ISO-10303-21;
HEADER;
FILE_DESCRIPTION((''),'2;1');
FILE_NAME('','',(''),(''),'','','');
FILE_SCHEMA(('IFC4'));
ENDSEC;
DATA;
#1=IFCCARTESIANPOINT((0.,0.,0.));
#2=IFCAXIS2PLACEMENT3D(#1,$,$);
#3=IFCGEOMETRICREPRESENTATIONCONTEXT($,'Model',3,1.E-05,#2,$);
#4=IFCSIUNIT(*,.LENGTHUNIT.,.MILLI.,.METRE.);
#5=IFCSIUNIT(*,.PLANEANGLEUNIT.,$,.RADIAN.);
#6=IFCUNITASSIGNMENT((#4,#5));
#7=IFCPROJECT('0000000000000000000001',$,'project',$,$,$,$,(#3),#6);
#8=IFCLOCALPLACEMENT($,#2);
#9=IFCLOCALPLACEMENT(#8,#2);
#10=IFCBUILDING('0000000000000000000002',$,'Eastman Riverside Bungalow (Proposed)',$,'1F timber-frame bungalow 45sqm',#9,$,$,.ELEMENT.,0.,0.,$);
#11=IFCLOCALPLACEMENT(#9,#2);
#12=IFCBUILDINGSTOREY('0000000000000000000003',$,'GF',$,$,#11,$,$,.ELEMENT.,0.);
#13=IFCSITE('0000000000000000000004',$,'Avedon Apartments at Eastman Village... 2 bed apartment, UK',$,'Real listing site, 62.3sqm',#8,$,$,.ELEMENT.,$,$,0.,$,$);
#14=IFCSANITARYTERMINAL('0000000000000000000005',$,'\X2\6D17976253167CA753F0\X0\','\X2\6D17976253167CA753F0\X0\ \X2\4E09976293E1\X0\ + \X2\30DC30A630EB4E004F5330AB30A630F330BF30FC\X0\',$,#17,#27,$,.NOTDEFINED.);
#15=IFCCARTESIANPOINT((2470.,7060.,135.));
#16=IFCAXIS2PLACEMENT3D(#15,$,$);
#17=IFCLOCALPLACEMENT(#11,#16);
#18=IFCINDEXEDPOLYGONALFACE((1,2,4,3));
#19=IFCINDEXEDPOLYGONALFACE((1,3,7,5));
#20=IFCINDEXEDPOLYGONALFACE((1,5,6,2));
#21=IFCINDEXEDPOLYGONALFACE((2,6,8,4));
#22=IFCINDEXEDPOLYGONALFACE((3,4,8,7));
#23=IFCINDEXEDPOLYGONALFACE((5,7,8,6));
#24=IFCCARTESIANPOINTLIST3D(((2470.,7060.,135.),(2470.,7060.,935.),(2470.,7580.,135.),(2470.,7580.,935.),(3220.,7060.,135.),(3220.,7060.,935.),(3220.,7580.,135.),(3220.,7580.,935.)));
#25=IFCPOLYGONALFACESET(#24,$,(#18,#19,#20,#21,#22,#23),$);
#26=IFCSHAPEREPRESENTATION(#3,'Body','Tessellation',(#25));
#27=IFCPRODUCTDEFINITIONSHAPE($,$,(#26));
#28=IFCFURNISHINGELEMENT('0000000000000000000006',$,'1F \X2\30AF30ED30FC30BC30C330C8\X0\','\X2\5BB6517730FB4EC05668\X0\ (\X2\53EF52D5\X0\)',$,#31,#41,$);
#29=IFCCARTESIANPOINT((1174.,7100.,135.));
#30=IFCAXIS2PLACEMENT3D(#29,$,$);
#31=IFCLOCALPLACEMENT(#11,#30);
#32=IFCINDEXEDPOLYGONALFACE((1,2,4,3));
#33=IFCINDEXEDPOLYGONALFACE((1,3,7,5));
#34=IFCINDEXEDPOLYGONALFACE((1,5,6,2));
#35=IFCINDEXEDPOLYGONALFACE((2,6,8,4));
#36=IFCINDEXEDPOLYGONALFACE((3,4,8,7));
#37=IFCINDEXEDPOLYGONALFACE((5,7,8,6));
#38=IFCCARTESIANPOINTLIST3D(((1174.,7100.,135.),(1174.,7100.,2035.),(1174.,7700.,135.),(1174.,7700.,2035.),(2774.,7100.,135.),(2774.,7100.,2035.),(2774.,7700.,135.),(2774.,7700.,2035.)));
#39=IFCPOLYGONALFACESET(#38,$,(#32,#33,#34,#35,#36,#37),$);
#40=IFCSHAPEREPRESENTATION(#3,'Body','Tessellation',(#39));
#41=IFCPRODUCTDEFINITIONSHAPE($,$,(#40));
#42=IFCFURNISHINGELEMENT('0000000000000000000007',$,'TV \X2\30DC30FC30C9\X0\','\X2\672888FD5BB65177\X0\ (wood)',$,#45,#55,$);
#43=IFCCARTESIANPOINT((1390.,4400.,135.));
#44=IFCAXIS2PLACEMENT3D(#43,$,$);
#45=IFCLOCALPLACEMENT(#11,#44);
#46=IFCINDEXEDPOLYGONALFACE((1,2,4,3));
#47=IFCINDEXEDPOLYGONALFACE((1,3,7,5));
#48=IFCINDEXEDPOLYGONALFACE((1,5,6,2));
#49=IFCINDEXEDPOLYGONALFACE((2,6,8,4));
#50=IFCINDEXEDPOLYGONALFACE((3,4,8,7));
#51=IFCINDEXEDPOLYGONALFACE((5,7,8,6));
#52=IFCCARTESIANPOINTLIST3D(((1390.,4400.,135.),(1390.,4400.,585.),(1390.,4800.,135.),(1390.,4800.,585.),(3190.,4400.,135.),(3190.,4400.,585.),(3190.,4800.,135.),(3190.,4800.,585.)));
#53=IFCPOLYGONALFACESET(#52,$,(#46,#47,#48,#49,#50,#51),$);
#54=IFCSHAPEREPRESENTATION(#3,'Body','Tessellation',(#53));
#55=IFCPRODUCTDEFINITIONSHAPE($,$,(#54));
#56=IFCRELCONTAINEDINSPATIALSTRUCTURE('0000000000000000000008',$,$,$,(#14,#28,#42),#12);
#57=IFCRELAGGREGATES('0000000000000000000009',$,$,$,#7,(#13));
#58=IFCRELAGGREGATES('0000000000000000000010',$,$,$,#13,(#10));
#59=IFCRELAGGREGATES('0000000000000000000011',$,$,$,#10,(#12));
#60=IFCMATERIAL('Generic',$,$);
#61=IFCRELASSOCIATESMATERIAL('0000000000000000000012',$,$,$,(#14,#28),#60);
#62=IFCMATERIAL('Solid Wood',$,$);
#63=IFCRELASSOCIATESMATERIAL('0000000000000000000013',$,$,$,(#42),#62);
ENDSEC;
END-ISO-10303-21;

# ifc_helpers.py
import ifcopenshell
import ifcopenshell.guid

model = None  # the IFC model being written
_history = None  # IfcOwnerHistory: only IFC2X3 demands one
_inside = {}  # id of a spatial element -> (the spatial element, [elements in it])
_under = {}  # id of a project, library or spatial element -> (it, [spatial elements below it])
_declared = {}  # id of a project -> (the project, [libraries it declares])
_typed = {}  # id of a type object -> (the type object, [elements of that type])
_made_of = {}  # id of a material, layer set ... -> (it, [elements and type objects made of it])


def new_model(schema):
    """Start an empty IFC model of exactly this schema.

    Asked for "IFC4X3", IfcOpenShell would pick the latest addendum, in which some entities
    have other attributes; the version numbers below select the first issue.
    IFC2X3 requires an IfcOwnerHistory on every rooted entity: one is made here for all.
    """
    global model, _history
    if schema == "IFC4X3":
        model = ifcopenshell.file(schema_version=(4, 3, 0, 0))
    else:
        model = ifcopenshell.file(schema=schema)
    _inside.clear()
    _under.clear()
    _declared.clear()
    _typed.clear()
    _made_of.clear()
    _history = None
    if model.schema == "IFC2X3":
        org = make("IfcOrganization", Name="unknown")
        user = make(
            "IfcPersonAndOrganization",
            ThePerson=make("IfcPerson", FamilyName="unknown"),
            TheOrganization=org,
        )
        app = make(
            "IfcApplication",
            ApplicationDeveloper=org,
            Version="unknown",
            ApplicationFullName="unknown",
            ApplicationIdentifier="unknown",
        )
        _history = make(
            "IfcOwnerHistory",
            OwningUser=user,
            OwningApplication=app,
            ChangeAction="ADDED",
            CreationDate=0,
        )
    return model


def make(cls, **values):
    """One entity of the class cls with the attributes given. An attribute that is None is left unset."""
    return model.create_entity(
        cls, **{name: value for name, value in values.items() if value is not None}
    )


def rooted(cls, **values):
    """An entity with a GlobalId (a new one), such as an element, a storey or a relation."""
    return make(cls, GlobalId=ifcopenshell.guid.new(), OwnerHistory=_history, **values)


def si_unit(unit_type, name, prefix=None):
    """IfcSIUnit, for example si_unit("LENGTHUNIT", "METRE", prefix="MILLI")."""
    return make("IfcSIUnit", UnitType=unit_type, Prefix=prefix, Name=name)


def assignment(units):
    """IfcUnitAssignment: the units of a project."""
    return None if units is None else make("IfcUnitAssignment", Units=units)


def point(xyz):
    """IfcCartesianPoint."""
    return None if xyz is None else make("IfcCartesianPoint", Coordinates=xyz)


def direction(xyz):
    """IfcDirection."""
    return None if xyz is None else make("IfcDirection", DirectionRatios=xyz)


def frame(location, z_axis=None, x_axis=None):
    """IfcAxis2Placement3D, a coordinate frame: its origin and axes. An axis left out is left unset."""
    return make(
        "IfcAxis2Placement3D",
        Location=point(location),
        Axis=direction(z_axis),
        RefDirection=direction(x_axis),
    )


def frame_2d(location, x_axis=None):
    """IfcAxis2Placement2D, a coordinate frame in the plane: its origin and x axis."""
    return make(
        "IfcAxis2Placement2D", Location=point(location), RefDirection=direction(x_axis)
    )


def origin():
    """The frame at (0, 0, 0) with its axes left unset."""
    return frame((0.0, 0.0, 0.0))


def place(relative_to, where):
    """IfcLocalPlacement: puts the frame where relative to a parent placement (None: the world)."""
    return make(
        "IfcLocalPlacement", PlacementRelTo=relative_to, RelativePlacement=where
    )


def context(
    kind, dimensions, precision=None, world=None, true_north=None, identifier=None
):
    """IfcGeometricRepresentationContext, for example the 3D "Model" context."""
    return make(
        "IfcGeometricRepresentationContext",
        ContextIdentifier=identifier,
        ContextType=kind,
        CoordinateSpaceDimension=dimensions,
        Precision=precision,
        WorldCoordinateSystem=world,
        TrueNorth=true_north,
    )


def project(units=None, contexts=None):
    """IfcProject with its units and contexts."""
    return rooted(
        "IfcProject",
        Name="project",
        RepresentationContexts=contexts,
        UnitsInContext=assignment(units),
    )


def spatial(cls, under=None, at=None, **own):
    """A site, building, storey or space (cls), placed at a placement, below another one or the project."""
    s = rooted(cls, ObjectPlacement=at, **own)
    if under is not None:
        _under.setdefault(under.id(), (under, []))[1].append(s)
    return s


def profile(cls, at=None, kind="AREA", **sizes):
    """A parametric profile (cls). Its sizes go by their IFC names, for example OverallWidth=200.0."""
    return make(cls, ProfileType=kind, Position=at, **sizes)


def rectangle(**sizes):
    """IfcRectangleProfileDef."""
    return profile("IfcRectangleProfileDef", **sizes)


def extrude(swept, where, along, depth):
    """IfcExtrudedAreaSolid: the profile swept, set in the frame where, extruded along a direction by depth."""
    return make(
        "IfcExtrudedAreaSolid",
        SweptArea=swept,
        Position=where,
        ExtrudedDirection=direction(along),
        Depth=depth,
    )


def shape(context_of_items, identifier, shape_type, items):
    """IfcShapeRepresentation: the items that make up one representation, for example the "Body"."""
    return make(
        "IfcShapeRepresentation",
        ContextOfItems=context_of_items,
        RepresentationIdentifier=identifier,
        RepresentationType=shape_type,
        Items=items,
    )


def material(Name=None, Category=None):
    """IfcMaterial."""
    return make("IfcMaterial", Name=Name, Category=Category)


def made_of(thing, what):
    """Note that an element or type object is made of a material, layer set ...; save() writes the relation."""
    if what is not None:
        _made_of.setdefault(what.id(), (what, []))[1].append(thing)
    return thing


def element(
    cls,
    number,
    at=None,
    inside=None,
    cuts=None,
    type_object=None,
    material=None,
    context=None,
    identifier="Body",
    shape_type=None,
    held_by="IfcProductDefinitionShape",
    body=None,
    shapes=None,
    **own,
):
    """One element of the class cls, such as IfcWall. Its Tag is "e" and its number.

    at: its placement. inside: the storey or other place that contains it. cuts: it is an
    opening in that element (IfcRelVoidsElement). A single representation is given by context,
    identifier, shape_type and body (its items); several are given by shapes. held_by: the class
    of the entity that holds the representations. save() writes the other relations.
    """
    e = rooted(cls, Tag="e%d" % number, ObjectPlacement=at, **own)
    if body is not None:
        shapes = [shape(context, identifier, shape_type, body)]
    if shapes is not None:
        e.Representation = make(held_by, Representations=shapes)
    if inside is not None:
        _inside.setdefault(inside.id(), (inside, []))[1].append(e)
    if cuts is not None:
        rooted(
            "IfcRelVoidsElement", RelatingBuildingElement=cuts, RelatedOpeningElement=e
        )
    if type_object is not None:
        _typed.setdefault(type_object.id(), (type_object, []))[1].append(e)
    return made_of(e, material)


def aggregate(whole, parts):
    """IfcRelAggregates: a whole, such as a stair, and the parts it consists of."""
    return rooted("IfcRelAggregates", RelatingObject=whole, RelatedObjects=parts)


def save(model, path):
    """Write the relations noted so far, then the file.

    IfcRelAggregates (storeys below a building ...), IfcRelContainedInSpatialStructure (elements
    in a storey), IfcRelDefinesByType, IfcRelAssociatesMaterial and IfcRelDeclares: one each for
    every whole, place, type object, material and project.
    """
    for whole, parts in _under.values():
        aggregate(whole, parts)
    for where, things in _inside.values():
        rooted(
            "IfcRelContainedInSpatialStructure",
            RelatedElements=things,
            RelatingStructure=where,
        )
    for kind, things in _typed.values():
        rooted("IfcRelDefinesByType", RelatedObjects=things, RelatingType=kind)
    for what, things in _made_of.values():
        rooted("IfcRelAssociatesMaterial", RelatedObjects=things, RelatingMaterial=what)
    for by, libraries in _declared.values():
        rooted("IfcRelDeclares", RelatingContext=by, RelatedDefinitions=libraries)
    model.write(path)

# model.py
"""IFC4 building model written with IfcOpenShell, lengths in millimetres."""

from ifc_helpers import new_model, si_unit, frame, frame_2d, origin, place, context, project, spatial, rectangle, extrude, material, element, save


model = new_model("IFC4")

# Units and contexts
model_context = context("Model", 3, precision=1e-05, world=origin())
ifc_project = project(units=[si_unit("LENGTHUNIT", "METRE", prefix="MILLI"), si_unit("PLANEANGLEUNIT", "RADIAN")], contexts=[model_context])

# Site, building, storey
site_placement = place(None, origin())
site = spatial("IfcSite", under=ifc_project, at=site_placement, Name="Avedon Apartments at Eastman Village... 2 bed apartment, UK", ObjectType="Real listing site, 62.3sqm", CompositionType="ELEMENT", RefElevation=0.0)
building_placement = place(site_placement, origin())
building = spatial("IfcBuilding", under=site, at=building_placement, Name="Eastman Riverside Bungalow (Proposed)", ObjectType="1F timber-frame bungalow 45sqm", CompositionType="ELEMENT", ElevationOfRefHeight=0.0, ElevationOfTerrain=0.0)
storey_placement = place(building_placement, origin())
storey = spatial("IfcBuildingStorey", under=building, at=storey_placement, Name="GF", CompositionType="ELEMENT", Elevation=0.0)

# Shared definitions
ifc_material_1 = material(Name="Solid Wood")

# Shared definitions
ifc_material_2 = material(Name="Generic")

# Sanitary terminal
sanitary_terminal_1_placement = place(storey_placement, frame((2470.0, 7060.0, 135.0)))
element("IfcSanitaryTerminal", 1, at=sanitary_terminal_1_placement, inside=storey, material=ifc_material_2, Name="洗面化粧台", Description="洗面化粧台 三面鏡 + ボウル一体カウンター", PredefinedType="NOTDEFINED", context=model_context, shape_type="SweptSolid", body=[
    extrude(rectangle(XDim=750.0, YDim=520.0, at=frame_2d((375.0, 260.0))), frame((2470.0, 7060.0, 135.0)), (0.0, 0.0, 1.0), 800.0),
])

# Furnishing elements
furnishing_1_placement = place(storey_placement, frame((1174.0, 7100.0, 135.0)))
element("IfcFurnishingElement", 2, at=furnishing_1_placement, inside=storey, material=ifc_material_2, Name="1F クローゼット", Description="家具・什器 (可動)", context=model_context, shape_type="SweptSolid", body=[
    extrude(rectangle(XDim=1600.0, YDim=600.0, at=frame_2d((800.0, 300.0))), frame((1174.0, 7100.0, 135.0)), (0.0, 0.0, 1.0), 1900.0),
])
furnishing_2_placement = place(storey_placement, frame((1390.0, 4400.0, 135.0)))
element("IfcFurnishingElement", 3, at=furnishing_2_placement, inside=storey, material=ifc_material_1, Name="TV ボード", Description="木製家具 (wood)", context=model_context, shape_type="SweptSolid", body=[
    extrude(rectangle(XDim=1800.0, YDim=400.0, at=frame_2d((900.0, 200.0))), frame((1390.0, 4400.0, 135.0)), (0.0, 0.0, 1.0), 450.0),
])

save(model, "model.ifc")
